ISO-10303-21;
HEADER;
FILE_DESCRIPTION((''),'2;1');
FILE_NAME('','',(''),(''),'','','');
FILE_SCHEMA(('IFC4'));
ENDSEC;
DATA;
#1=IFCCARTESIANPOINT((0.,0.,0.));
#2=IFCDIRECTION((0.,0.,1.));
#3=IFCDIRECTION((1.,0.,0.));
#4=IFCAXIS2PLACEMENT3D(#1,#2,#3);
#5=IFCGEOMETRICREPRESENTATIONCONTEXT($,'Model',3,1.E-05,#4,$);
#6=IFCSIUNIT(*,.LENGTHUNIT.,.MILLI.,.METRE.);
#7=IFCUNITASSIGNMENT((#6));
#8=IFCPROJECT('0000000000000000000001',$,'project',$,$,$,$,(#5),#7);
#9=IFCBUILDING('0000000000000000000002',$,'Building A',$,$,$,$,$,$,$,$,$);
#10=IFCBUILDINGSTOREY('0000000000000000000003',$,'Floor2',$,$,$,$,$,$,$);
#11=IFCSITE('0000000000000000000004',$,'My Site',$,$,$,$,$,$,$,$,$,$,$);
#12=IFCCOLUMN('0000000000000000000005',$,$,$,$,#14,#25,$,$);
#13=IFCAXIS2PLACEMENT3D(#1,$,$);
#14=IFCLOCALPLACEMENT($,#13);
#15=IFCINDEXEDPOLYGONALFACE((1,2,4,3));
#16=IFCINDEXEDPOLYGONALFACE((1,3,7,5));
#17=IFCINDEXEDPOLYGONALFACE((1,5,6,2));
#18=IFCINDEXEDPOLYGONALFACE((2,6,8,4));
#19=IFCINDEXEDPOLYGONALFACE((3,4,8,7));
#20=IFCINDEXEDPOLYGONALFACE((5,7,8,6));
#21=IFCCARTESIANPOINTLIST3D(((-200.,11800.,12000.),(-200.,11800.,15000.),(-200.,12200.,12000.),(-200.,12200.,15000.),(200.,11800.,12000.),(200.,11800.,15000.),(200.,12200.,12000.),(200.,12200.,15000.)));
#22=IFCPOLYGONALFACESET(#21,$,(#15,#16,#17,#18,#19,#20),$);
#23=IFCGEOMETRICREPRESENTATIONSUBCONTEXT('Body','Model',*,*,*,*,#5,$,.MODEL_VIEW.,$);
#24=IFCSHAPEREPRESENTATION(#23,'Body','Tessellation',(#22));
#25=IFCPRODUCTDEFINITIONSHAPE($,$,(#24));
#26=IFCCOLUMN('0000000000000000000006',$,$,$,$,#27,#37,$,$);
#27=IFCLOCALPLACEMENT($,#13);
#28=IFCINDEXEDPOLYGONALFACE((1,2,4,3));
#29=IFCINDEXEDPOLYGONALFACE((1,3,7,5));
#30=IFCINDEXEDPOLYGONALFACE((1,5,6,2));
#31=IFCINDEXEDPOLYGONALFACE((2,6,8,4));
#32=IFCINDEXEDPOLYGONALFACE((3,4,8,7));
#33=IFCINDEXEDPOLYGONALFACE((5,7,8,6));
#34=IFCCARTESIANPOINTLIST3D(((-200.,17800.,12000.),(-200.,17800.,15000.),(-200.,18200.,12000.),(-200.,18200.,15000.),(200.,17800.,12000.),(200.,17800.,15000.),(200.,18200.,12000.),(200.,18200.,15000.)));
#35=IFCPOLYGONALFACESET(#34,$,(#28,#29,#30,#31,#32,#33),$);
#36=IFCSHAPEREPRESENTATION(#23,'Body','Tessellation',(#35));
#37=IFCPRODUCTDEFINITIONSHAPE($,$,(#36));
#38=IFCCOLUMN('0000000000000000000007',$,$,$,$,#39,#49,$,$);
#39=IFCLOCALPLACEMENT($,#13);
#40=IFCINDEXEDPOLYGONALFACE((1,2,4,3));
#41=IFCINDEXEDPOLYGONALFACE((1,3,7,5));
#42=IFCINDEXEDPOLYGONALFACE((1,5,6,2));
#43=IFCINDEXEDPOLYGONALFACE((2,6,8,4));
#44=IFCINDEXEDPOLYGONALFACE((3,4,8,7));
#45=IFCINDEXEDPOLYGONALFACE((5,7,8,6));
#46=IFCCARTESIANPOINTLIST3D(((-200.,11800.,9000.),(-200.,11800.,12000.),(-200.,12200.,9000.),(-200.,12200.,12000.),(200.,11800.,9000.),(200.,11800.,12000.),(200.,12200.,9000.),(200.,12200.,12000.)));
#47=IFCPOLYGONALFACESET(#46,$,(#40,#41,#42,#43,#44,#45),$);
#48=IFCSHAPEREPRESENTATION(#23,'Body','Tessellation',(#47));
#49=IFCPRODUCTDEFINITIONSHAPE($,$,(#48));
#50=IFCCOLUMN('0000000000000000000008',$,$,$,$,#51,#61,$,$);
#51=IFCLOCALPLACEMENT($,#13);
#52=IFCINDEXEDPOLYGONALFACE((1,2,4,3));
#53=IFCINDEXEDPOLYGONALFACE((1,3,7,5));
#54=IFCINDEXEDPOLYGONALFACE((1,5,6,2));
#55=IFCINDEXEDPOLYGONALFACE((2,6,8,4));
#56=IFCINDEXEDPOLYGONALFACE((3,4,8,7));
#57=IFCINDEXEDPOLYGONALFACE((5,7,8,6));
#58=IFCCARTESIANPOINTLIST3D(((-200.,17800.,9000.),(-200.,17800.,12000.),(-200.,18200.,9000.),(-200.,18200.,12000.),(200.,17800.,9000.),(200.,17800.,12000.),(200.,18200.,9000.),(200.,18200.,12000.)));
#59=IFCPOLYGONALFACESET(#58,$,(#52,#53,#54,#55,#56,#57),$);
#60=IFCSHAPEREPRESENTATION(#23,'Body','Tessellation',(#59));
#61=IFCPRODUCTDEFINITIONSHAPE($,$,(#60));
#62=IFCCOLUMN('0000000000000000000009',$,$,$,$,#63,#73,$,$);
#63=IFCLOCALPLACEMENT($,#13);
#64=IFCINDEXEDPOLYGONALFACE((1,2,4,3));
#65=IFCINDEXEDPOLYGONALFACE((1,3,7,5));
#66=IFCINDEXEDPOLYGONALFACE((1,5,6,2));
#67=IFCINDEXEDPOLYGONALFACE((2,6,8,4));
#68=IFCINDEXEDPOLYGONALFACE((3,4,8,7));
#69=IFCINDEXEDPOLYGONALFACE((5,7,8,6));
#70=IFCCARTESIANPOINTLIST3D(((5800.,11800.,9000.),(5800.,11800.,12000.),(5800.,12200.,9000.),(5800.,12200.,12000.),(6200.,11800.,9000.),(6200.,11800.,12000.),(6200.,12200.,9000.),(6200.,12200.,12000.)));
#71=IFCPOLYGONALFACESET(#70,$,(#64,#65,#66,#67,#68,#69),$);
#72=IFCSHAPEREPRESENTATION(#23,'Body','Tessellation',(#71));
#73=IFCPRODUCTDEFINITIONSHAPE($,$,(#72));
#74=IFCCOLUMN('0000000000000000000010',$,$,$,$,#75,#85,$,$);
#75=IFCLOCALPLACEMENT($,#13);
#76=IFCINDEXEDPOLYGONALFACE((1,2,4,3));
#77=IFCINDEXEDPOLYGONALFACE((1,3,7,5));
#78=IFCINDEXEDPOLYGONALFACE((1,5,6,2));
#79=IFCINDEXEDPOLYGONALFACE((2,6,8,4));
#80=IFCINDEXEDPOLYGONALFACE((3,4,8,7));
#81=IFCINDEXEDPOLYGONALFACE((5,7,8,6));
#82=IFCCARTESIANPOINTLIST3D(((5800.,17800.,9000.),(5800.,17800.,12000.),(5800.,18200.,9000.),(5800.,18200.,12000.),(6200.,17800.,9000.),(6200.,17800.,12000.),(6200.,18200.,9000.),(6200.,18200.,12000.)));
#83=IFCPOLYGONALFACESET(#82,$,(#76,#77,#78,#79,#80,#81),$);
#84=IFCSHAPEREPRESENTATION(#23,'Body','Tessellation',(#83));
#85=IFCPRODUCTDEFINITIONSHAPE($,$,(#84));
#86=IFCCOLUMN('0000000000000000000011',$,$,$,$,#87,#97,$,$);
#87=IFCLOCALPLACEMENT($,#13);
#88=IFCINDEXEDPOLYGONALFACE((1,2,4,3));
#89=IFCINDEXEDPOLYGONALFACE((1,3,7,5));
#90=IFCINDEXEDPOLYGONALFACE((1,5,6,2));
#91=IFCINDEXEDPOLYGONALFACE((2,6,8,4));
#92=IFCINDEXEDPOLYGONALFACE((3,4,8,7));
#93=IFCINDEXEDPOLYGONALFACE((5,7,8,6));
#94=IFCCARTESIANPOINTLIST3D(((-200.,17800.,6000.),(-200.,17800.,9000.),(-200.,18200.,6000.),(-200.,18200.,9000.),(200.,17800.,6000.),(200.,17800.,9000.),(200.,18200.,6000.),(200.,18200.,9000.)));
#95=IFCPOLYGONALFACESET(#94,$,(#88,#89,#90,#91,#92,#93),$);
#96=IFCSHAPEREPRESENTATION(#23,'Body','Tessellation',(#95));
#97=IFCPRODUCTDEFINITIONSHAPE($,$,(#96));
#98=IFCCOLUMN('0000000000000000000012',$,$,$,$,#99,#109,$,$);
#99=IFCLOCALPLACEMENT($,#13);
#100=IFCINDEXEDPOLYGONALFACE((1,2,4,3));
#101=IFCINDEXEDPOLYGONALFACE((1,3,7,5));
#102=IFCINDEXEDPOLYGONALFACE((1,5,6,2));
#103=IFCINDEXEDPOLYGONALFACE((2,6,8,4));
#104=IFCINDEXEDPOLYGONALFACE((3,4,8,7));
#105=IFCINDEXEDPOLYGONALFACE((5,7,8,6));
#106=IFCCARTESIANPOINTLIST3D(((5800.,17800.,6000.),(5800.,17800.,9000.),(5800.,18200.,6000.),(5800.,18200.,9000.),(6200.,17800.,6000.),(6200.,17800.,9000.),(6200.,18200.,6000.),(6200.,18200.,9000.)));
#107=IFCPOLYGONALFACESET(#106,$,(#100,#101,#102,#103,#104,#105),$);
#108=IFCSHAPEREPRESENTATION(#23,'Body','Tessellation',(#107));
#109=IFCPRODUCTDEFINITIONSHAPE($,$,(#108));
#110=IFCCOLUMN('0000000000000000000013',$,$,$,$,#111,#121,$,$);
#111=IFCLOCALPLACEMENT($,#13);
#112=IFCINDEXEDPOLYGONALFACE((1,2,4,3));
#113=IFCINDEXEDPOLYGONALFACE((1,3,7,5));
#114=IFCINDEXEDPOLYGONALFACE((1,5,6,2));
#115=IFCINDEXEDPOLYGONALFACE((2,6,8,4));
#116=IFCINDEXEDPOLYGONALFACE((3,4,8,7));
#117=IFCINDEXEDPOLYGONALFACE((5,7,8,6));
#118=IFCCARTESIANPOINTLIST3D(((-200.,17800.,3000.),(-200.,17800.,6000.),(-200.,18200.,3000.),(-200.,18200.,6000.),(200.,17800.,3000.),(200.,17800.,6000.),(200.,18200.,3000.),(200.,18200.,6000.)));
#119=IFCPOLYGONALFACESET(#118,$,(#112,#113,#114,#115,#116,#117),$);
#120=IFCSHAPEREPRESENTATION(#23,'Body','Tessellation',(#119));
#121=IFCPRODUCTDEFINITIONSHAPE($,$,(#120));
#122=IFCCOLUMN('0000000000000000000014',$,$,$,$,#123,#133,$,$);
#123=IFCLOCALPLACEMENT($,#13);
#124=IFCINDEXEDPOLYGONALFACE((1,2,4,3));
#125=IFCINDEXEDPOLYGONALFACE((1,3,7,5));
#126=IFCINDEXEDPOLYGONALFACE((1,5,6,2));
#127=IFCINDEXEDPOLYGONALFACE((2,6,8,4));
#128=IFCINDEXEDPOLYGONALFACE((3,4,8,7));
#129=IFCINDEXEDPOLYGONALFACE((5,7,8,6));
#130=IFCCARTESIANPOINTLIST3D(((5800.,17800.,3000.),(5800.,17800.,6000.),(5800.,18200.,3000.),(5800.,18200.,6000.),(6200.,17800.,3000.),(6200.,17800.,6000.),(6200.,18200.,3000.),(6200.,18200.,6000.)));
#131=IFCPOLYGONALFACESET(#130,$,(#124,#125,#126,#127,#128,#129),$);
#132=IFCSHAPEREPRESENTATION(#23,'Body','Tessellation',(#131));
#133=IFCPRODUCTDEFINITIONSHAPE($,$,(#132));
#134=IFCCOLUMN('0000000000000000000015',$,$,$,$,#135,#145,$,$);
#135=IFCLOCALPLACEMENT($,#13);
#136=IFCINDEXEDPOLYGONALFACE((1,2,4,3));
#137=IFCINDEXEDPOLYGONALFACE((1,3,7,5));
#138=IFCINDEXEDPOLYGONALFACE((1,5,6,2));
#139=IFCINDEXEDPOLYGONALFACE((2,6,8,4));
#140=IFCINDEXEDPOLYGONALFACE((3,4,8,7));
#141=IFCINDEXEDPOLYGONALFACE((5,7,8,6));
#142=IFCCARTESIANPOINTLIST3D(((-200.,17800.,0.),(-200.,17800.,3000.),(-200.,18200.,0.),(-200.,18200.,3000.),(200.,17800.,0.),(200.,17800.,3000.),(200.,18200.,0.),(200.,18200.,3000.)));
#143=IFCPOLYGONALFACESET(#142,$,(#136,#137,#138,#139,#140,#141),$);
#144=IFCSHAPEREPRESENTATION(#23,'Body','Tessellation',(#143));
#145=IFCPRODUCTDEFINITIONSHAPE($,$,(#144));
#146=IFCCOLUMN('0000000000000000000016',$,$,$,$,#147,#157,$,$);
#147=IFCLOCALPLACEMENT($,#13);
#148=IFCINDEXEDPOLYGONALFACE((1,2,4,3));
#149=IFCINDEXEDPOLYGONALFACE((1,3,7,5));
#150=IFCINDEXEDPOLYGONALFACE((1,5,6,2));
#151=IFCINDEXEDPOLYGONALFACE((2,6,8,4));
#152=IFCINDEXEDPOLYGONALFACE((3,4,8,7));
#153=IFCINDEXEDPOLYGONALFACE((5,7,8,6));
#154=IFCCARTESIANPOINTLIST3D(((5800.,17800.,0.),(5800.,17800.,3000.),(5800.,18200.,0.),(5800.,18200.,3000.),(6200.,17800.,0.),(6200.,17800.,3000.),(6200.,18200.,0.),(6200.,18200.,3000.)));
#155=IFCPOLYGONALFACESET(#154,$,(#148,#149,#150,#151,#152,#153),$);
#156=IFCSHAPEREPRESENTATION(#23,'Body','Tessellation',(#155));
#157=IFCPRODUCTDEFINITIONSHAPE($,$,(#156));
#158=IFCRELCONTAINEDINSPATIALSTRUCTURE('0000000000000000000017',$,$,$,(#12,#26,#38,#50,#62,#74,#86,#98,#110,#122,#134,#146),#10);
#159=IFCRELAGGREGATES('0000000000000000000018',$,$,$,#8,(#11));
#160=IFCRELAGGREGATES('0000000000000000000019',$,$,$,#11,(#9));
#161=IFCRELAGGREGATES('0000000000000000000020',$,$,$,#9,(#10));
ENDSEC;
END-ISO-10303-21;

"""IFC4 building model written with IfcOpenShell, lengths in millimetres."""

from ifc_helpers import new_model, si_unit, frame, origin_with_axes, place, context, subcontext, project, spatial, line, indexed_curve, outline, extrude, element, save


model = new_model("IFC4")

# Units and contexts
model_context = context("Model", 3, precision=1e-05, world=origin_with_axes())
body_context = subcontext(model_context, "Body", "Model", "MODEL_VIEW")
ifc_project = project(units=[si_unit("LENGTHUNIT", "METRE", prefix="MILLI")], contexts=[model_context])

# Site, building, storey
site = spatial("IfcSite", under=ifc_project, Name="My Site")
building = spatial("IfcBuilding", under=site, Name="Building A")
storey = spatial("IfcBuildingStorey", under=building, Name="Floor2")

# Columns
for number, where, z_axis, x_axis in (
    (1, (0.0, 12000.0, 12000.0), (0.0, 0.0, 1.0), (1.0, 0.0, 0.0)),
    (2, (0.0, 18000.0, 12000.0), (0.0, 0.0, 1.0), (1.0, 0.0, 0.0)),
    (3, (0.0, 12000.0, 9000.0), (0.0, 0.0, 1.0), (1.0, 0.0, 0.0)),
    (4, (0.0, 18000.0, 9000.0), (0.0, 0.0, 1.0), (1.0, 0.0, 0.0)),
    (5, (6000.0, 12000.0, 9000.0), (0.0, 0.0, 1.0), (1.0, 0.0, 0.0)),
    (6, (6000.0, 18000.0, 9000.0), (0.0, 0.0, 1.0), (1.0, 0.0, 0.0)),
    (7, (0.0, 18000.0, 6000.0), (0.0, 0.0, 1.0), (1.0, 0.0, 0.0)),
    (8, (6000.0, 18000.0, 6000.0), (0.0, 0.0, 1.0), (1.0, 0.0, 0.0)),
    (9, (0.0, 18000.0, 3000.0), (0.0, 0.0, 1.0), (1.0, 0.0, 0.0)),
    (10, (6000.0, 18000.0, 3000.0), (0.0, 0.0, 1.0), (1.0, 0.0, 0.0)),
    (11, (0.0, 18000.0, 0.0), (0.0, 0.0, 1.0), (1.0, 0.0, 0.0)),
    (12, (6000.0, 18000.0, 0.0), (0.0, 0.0, 1.0), (1.0, 0.0, 0.0)),
):
    element("IfcColumn", number, at=place(None, frame(where, z_axis=z_axis, x_axis=x_axis)), inside=storey, context=body_context, shape_type="SweptSolid", body=[
        extrude(outline(indexed_curve([(-200.0, -200.0), (200.0, -200.0), (200.0, 200.0), (-200.0, 200.0)], segments=[line(1, 2, 3, 4, 1)])), origin_with_axes(), (0.0, 0.0, 1.0), 3000.0),
    ])

save(model, "model.ifc")
